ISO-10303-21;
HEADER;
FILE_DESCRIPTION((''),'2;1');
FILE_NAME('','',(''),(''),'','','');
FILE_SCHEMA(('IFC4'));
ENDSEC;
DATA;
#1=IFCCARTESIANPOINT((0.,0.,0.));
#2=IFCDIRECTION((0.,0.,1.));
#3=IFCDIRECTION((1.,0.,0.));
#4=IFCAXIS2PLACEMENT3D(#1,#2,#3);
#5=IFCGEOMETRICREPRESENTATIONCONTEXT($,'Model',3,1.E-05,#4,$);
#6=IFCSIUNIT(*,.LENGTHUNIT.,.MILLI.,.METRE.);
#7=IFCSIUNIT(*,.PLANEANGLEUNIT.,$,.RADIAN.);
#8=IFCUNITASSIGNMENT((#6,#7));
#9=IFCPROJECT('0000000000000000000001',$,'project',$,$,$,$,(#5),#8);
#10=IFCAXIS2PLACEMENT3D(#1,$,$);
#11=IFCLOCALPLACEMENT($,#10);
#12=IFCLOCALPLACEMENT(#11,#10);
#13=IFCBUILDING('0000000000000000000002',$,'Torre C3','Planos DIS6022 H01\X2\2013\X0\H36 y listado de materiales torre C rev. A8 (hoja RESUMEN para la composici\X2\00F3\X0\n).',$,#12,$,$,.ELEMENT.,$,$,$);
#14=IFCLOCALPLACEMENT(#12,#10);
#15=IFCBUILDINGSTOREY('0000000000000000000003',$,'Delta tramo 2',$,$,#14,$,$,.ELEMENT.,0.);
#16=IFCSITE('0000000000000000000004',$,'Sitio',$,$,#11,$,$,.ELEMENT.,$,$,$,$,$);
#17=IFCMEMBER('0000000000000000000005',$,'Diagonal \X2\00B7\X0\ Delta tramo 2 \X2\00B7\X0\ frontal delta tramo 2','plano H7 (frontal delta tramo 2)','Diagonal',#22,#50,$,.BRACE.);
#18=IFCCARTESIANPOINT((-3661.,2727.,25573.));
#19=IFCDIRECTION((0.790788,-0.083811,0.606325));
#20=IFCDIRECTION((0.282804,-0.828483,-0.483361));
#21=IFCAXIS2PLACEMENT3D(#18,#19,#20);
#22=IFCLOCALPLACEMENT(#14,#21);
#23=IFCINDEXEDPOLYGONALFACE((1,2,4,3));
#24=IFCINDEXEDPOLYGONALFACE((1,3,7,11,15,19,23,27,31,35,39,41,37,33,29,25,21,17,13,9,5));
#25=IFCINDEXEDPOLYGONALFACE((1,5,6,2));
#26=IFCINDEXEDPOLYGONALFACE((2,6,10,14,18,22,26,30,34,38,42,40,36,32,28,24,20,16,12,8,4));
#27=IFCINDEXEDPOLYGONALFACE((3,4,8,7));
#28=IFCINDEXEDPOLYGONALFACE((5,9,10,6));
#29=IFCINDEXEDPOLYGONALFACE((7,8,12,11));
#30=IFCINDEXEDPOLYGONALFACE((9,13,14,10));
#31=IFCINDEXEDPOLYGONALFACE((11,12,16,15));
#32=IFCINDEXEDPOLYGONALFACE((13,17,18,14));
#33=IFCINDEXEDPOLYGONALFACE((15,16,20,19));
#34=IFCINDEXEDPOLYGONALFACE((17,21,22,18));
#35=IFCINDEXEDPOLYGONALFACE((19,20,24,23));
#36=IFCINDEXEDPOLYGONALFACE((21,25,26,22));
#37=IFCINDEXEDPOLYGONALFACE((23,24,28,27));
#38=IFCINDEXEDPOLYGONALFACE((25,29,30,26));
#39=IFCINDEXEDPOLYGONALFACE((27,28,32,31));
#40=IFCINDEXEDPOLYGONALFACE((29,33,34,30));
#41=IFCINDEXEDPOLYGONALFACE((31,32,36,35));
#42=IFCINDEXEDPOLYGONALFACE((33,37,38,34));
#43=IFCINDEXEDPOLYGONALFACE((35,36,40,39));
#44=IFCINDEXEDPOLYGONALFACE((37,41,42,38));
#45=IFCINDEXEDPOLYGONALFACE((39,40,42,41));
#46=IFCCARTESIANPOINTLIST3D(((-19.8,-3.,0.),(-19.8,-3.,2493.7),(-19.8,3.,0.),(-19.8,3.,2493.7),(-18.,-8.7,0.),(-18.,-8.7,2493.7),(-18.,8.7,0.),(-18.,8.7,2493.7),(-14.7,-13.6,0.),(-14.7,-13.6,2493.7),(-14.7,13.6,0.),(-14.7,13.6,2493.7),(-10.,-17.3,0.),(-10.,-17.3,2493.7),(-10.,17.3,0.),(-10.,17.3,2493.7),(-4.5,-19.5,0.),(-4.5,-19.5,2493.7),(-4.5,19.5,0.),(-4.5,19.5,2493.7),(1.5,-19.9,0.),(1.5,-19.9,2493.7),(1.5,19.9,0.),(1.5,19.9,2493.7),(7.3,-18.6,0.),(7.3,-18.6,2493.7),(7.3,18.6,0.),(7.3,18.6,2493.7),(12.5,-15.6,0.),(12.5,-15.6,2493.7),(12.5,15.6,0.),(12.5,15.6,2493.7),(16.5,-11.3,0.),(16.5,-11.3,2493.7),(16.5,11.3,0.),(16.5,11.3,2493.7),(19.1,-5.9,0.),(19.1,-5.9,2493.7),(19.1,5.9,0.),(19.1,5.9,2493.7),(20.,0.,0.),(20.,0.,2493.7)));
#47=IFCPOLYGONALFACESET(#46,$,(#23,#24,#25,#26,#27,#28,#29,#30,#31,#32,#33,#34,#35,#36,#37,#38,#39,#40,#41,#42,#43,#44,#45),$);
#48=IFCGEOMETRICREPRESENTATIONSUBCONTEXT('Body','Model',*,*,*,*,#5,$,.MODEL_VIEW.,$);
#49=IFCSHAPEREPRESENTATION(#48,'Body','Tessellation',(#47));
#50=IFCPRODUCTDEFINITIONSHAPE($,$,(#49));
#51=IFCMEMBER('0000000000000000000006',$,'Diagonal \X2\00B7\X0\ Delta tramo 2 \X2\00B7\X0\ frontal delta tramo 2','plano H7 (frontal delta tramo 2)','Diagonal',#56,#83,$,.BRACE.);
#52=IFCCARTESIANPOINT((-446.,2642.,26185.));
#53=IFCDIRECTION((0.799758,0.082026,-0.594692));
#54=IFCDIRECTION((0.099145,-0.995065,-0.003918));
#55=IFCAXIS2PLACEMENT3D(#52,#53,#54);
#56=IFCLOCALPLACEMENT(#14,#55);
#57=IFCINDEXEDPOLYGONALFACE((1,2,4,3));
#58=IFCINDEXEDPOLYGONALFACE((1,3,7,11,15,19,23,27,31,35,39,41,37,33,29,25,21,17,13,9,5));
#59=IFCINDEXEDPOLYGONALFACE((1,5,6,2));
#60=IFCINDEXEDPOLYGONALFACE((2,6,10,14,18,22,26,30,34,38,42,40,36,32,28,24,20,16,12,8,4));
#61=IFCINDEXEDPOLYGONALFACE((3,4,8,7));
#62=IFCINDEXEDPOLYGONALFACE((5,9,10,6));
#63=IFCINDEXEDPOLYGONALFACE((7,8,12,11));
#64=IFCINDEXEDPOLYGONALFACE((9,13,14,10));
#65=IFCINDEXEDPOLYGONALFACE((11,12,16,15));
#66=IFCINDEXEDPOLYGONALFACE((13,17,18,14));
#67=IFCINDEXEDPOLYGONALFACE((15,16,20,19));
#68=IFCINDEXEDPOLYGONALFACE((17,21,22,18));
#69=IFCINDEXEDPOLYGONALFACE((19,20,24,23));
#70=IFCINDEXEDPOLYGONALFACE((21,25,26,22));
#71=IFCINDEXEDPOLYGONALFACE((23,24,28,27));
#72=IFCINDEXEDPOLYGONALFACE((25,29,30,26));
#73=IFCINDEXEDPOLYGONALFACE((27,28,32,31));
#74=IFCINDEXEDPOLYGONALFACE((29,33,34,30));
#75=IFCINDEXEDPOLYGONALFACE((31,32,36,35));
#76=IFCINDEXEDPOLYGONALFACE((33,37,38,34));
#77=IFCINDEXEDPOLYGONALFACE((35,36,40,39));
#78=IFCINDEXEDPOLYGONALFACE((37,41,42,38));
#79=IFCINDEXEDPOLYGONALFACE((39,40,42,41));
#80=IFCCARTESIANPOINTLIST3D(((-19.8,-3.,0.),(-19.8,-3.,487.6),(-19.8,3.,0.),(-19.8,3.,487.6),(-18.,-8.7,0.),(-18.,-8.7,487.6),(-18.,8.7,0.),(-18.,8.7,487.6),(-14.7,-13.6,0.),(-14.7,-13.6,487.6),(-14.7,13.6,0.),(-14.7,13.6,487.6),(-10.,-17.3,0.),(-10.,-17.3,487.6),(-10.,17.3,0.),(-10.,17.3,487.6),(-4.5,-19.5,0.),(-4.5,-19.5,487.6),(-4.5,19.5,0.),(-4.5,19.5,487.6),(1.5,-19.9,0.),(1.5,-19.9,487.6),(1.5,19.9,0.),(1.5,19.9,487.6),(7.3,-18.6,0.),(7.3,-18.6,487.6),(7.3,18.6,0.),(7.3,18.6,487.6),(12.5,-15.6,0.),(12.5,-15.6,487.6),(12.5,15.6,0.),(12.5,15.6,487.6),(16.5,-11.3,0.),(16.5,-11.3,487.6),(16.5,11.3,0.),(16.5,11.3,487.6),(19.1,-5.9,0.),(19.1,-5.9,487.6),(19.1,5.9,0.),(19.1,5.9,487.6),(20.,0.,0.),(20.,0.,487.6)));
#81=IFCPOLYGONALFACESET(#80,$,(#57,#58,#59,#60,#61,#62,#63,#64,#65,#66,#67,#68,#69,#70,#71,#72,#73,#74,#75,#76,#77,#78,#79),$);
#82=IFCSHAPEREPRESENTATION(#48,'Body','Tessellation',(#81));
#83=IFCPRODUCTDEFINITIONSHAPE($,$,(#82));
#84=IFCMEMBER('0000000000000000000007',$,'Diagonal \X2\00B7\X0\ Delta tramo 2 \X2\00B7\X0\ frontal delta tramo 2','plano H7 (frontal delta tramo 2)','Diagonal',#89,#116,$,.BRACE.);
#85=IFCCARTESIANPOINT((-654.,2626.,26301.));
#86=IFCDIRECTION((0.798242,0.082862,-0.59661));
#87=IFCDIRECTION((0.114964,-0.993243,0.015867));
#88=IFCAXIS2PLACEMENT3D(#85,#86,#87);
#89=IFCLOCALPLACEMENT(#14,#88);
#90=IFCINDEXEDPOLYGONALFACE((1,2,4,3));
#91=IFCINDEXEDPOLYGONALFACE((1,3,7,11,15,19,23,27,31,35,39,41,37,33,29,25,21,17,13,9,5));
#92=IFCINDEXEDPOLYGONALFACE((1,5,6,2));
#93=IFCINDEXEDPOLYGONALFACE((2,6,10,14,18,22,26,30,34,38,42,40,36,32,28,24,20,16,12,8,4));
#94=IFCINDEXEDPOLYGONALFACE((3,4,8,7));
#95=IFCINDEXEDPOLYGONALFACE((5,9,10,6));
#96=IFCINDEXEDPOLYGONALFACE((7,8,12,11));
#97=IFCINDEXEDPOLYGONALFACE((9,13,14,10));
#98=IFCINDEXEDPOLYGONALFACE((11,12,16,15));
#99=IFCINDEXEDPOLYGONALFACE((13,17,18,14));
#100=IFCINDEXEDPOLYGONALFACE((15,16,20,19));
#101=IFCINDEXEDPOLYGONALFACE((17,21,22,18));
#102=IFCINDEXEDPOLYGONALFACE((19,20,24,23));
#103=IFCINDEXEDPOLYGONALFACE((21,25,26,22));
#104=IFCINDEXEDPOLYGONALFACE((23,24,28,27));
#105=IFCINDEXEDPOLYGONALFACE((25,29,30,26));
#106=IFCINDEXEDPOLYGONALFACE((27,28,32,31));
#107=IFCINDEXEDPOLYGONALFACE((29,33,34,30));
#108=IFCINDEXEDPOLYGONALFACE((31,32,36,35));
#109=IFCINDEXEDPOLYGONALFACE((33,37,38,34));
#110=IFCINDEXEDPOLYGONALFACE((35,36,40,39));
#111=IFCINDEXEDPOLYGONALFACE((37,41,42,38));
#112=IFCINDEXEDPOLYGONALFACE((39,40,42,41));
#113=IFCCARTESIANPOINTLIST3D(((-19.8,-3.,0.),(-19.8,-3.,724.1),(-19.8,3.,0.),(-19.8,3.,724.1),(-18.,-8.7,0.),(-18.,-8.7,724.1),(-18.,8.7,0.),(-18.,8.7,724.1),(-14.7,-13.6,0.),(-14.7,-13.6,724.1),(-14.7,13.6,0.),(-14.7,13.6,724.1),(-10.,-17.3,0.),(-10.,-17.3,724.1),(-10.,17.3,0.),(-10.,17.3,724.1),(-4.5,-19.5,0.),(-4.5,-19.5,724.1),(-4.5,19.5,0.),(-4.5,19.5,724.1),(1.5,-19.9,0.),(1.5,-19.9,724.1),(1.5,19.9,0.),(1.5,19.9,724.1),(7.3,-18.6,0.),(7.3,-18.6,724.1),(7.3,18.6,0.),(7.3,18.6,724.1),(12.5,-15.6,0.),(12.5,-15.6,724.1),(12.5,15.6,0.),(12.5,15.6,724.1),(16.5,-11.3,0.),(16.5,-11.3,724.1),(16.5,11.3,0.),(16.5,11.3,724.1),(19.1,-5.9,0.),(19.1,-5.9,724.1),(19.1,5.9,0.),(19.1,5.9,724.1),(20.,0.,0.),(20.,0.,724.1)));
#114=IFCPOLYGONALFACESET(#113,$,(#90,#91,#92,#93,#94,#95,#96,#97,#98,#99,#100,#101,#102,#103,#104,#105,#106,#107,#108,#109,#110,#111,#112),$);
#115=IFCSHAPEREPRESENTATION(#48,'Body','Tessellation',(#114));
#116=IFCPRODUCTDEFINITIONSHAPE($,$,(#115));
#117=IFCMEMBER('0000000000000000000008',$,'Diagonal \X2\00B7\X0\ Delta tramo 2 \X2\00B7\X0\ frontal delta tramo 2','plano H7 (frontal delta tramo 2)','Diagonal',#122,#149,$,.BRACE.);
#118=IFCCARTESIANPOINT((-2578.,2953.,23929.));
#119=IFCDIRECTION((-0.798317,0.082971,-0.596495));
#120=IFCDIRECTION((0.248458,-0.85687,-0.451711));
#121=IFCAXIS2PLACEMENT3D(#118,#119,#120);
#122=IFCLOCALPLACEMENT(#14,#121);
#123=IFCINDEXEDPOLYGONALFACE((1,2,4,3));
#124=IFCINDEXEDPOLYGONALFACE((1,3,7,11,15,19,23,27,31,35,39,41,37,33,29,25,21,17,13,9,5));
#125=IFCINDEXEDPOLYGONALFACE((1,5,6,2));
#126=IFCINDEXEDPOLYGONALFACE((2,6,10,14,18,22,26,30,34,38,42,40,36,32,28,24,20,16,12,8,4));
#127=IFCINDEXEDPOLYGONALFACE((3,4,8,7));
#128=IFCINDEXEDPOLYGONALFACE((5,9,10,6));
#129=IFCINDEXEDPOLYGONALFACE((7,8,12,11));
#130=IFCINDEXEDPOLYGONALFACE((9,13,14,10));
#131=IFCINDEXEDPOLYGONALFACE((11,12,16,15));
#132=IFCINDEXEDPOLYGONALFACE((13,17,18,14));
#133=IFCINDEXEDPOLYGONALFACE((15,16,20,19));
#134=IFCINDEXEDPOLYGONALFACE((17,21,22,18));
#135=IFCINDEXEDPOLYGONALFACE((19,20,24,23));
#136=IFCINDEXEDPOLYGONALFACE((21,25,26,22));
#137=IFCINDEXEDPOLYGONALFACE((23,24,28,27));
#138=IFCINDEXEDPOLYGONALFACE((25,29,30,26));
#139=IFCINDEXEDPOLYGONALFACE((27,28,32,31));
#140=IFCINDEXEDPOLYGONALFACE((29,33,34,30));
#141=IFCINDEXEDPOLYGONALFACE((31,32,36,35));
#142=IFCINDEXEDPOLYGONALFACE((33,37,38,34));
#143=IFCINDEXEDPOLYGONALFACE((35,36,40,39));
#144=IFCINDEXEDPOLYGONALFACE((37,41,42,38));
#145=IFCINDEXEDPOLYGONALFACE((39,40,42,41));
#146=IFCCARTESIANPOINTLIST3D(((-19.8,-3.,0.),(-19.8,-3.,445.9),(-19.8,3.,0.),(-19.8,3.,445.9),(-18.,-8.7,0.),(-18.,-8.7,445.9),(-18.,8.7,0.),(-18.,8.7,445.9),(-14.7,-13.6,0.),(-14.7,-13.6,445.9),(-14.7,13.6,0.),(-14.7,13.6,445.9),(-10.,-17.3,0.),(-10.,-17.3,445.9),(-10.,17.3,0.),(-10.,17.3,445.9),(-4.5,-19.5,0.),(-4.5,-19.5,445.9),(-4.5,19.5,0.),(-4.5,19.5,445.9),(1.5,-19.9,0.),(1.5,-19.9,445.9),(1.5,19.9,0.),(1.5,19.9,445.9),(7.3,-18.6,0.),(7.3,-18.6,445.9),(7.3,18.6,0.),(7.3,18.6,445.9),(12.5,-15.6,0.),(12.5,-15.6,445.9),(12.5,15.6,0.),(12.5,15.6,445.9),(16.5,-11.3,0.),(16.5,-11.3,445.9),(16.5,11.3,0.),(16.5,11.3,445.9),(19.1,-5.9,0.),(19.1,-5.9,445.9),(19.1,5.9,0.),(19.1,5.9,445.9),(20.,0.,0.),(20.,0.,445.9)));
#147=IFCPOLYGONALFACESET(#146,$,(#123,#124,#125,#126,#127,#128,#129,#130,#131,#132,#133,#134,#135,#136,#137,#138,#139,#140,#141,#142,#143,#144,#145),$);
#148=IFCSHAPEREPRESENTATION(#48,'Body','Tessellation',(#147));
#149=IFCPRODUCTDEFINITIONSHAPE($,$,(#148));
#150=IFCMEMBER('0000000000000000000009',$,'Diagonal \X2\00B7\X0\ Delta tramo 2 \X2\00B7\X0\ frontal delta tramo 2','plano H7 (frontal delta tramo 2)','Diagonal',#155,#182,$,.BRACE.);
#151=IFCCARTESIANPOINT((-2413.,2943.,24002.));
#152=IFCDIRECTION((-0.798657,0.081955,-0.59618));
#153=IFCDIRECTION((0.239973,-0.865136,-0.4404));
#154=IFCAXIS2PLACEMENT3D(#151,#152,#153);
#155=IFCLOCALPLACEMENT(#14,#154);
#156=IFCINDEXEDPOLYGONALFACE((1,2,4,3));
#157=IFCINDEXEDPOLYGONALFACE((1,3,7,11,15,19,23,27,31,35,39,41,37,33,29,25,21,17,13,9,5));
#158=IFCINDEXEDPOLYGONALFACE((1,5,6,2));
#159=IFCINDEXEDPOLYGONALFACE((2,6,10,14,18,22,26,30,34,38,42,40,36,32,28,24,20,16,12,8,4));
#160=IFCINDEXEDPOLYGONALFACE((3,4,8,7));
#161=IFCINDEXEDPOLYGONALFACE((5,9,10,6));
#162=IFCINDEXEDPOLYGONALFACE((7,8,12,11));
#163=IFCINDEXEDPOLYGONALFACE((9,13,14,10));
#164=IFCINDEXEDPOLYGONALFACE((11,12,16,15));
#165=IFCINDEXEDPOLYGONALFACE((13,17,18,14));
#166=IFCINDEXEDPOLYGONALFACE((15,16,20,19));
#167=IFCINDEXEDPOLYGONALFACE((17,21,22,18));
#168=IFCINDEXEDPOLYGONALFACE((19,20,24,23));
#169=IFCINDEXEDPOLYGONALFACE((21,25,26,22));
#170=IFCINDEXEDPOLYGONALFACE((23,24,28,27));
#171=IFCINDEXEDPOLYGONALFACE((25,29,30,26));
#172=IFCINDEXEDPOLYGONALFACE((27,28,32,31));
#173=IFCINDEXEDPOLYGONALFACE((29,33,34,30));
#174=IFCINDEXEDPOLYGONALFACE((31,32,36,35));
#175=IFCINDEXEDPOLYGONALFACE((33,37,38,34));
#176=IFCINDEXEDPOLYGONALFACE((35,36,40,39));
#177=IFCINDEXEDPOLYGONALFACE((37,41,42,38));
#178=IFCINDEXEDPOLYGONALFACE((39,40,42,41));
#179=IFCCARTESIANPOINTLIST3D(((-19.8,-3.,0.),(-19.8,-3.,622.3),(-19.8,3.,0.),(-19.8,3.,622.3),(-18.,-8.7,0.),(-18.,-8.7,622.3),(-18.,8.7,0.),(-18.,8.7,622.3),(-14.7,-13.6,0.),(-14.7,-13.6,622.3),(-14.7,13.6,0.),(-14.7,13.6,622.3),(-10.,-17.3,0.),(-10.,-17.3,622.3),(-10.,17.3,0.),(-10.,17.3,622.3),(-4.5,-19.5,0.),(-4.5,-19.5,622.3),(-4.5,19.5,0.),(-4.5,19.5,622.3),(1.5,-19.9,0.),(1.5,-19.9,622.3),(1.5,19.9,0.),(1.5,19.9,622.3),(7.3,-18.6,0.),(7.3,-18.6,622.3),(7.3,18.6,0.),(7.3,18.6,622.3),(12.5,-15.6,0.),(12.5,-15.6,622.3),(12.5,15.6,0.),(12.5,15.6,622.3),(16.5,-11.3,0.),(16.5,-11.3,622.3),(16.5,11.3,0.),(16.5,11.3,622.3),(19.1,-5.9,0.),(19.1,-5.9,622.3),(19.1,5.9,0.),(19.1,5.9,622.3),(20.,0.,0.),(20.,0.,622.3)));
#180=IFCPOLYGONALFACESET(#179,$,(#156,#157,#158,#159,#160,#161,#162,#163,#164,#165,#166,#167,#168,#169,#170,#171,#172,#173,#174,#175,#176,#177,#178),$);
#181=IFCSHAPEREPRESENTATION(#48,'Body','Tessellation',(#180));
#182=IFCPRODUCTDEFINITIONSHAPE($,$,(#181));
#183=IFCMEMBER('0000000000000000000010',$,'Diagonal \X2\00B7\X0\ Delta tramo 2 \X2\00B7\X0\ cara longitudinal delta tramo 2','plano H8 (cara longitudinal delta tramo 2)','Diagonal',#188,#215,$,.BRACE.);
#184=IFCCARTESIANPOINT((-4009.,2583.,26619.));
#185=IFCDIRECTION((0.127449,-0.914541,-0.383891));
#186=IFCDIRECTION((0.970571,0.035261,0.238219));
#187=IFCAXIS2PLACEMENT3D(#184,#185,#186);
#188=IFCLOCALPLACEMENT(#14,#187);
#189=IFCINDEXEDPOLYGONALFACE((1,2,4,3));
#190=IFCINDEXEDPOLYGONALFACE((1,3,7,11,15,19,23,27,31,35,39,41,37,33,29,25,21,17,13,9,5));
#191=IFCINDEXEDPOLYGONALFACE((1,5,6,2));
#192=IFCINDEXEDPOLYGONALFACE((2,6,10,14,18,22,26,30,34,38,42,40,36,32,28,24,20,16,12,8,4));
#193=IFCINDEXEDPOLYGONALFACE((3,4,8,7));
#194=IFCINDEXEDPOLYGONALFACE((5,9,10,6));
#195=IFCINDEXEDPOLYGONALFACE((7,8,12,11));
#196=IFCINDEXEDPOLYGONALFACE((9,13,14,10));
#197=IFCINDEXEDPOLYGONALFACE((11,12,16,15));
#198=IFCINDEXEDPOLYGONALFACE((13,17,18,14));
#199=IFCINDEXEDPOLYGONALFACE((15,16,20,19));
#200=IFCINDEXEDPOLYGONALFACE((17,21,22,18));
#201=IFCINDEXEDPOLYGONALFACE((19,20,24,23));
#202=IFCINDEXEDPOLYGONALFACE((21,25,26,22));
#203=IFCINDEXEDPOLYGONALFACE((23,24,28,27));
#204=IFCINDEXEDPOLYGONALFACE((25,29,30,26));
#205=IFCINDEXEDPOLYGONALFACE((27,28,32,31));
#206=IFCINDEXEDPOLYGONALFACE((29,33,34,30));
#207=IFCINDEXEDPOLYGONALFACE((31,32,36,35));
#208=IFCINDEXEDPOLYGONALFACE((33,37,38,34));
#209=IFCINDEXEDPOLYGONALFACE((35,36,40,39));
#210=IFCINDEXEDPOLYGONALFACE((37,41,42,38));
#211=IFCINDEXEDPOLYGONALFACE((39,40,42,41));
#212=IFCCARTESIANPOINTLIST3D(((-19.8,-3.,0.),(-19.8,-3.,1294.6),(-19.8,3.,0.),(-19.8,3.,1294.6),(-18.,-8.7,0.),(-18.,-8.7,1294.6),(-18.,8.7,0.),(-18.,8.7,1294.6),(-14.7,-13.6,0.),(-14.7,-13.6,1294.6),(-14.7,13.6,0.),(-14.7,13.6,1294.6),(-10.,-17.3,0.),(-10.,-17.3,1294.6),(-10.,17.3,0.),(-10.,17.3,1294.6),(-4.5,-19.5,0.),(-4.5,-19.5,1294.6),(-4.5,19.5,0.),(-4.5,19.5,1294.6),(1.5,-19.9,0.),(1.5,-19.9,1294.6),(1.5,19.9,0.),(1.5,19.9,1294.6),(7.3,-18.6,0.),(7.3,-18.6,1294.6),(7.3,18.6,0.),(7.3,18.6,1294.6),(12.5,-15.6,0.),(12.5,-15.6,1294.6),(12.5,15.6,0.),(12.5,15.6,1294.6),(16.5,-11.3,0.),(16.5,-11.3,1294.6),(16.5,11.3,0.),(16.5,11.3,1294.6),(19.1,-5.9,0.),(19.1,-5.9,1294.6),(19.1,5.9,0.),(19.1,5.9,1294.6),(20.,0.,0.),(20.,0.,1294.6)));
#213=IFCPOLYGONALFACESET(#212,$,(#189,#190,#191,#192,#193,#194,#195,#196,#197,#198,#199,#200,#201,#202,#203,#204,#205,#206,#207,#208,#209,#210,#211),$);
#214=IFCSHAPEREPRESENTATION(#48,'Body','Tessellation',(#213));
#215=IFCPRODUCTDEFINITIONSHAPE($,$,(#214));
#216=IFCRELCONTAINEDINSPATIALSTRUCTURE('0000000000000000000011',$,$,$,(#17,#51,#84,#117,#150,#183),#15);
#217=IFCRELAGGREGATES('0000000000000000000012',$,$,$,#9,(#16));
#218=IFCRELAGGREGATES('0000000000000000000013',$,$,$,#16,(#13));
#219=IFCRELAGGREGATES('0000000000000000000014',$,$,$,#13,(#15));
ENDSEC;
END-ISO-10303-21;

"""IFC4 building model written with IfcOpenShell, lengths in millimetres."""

from ifc_helpers import new_model, si_unit, frame, origin, origin_with_axes, place, context, subcontext, project, spatial, circle, extrude, element, save


model = new_model("IFC4")

# Units and contexts
model_context = context("Model", 3, precision=1e-05, world=origin_with_axes())
body_context = subcontext(model_context, "Body", "Model", "MODEL_VIEW")
ifc_project = project(units=[si_unit("LENGTHUNIT", "METRE", prefix="MILLI"), si_unit("PLANEANGLEUNIT", "RADIAN")], contexts=[model_context])

# Site, building, storey
site_placement = place(None, origin())
site = spatial("IfcSite", under=ifc_project, at=site_placement, Name="Sitio", CompositionType="ELEMENT")
building_placement = place(site_placement, origin())
building = spatial("IfcBuilding", under=site, at=building_placement, Name="Torre C3", Description="Planos DIS6022 H01–H36 y listado de materiales torre C rev. A8 (hoja RESUMEN para la composición).", CompositionType="ELEMENT")
storey_placement = place(building_placement, origin())
storey = spatial("IfcBuildingStorey", under=building, at=storey_placement, Name="Delta tramo 2", CompositionType="ELEMENT", Elevation=0.0)

# Members
member_1_placement = place(storey_placement, frame((-3661.0, 2727.0, 25573.0), z_axis=(0.790788, -0.083811, 0.606325), x_axis=(0.282804, -0.828483, -0.483361)))
element("IfcMember", 1, at=member_1_placement, inside=storey, Name="Diagonal · Delta tramo 2 · frontal delta tramo 2", Description="plano H7 (frontal delta tramo 2)", ObjectType="Diagonal", PredefinedType="BRACE", context=body_context, shape_type="SweptSolid", body=[
    extrude(circle(Radius=20.0), None, (0.0, 0.0, 1.0), 2493.7),
])
member_2_placement = place(storey_placement, frame((-446.0, 2642.0, 26185.0), z_axis=(0.799758, 0.082026, -0.594692), x_axis=(0.099145, -0.995065, -0.003918)))
element("IfcMember", 2, at=member_2_placement, inside=storey, Name="Diagonal · Delta tramo 2 · frontal delta tramo 2", Description="plano H7 (frontal delta tramo 2)", ObjectType="Diagonal", PredefinedType="BRACE", context=body_context, shape_type="SweptSolid", body=[
    extrude(circle(Radius=20.0), None, (0.0, 0.0, 1.0), 487.6),
])
member_3_placement = place(storey_placement, frame((-654.0, 2626.0, 26301.0), z_axis=(0.798242, 0.082862, -0.59661), x_axis=(0.114964, -0.993243, 0.015867)))
element("IfcMember", 3, at=member_3_placement, inside=storey, Name="Diagonal · Delta tramo 2 · frontal delta tramo 2", Description="plano H7 (frontal delta tramo 2)", ObjectType="Diagonal", PredefinedType="BRACE", context=body_context, shape_type="SweptSolid", body=[
    extrude(circle(Radius=20.0), None, (0.0, 0.0, 1.0), 724.1),
])
member_4_placement = place(storey_placement, frame((-2578.0, 2953.0, 23929.0), z_axis=(-0.798317, 0.082971, -0.596495), x_axis=(0.248458, -0.85687, -0.451711)))
element("IfcMember", 4, at=member_4_placement, inside=storey, Name="Diagonal · Delta tramo 2 · frontal delta tramo 2", Description="plano H7 (frontal delta tramo 2)", ObjectType="Diagonal", PredefinedType="BRACE", context=body_context, shape_type="SweptSolid", body=[
    extrude(circle(Radius=20.0), None, (0.0, 0.0, 1.0), 445.9),
])
member_5_placement = place(storey_placement, frame((-2413.0, 2943.0, 24002.0), z_axis=(-0.798657, 0.081955, -0.59618), x_axis=(0.239973, -0.865136, -0.4404)))
element("IfcMember", 5, at=member_5_placement, inside=storey, Name="Diagonal · Delta tramo 2 · frontal delta tramo 2", Description="plano H7 (frontal delta tramo 2)", ObjectType="Diagonal", PredefinedType="BRACE", context=body_context, shape_type="SweptSolid", body=[
    extrude(circle(Radius=20.0), None, (0.0, 0.0, 1.0), 622.3),
])
member_6_placement = place(storey_placement, frame((-4009.0, 2583.0, 26619.0), z_axis=(0.127449, -0.914541, -0.383891), x_axis=(0.970571, 0.035261, 0.238219)))
element("IfcMember", 6, at=member_6_placement, inside=storey, Name="Diagonal · Delta tramo 2 · cara longitudinal delta tramo 2", Description="plano H8 (cara longitudinal delta tramo 2)", ObjectType="Diagonal", PredefinedType="BRACE", context=body_context, shape_type="SweptSolid", body=[
    extrude(circle(Radius=20.0), None, (0.0, 0.0, 1.0), 1294.6),
])

save(model, "model.ifc")
